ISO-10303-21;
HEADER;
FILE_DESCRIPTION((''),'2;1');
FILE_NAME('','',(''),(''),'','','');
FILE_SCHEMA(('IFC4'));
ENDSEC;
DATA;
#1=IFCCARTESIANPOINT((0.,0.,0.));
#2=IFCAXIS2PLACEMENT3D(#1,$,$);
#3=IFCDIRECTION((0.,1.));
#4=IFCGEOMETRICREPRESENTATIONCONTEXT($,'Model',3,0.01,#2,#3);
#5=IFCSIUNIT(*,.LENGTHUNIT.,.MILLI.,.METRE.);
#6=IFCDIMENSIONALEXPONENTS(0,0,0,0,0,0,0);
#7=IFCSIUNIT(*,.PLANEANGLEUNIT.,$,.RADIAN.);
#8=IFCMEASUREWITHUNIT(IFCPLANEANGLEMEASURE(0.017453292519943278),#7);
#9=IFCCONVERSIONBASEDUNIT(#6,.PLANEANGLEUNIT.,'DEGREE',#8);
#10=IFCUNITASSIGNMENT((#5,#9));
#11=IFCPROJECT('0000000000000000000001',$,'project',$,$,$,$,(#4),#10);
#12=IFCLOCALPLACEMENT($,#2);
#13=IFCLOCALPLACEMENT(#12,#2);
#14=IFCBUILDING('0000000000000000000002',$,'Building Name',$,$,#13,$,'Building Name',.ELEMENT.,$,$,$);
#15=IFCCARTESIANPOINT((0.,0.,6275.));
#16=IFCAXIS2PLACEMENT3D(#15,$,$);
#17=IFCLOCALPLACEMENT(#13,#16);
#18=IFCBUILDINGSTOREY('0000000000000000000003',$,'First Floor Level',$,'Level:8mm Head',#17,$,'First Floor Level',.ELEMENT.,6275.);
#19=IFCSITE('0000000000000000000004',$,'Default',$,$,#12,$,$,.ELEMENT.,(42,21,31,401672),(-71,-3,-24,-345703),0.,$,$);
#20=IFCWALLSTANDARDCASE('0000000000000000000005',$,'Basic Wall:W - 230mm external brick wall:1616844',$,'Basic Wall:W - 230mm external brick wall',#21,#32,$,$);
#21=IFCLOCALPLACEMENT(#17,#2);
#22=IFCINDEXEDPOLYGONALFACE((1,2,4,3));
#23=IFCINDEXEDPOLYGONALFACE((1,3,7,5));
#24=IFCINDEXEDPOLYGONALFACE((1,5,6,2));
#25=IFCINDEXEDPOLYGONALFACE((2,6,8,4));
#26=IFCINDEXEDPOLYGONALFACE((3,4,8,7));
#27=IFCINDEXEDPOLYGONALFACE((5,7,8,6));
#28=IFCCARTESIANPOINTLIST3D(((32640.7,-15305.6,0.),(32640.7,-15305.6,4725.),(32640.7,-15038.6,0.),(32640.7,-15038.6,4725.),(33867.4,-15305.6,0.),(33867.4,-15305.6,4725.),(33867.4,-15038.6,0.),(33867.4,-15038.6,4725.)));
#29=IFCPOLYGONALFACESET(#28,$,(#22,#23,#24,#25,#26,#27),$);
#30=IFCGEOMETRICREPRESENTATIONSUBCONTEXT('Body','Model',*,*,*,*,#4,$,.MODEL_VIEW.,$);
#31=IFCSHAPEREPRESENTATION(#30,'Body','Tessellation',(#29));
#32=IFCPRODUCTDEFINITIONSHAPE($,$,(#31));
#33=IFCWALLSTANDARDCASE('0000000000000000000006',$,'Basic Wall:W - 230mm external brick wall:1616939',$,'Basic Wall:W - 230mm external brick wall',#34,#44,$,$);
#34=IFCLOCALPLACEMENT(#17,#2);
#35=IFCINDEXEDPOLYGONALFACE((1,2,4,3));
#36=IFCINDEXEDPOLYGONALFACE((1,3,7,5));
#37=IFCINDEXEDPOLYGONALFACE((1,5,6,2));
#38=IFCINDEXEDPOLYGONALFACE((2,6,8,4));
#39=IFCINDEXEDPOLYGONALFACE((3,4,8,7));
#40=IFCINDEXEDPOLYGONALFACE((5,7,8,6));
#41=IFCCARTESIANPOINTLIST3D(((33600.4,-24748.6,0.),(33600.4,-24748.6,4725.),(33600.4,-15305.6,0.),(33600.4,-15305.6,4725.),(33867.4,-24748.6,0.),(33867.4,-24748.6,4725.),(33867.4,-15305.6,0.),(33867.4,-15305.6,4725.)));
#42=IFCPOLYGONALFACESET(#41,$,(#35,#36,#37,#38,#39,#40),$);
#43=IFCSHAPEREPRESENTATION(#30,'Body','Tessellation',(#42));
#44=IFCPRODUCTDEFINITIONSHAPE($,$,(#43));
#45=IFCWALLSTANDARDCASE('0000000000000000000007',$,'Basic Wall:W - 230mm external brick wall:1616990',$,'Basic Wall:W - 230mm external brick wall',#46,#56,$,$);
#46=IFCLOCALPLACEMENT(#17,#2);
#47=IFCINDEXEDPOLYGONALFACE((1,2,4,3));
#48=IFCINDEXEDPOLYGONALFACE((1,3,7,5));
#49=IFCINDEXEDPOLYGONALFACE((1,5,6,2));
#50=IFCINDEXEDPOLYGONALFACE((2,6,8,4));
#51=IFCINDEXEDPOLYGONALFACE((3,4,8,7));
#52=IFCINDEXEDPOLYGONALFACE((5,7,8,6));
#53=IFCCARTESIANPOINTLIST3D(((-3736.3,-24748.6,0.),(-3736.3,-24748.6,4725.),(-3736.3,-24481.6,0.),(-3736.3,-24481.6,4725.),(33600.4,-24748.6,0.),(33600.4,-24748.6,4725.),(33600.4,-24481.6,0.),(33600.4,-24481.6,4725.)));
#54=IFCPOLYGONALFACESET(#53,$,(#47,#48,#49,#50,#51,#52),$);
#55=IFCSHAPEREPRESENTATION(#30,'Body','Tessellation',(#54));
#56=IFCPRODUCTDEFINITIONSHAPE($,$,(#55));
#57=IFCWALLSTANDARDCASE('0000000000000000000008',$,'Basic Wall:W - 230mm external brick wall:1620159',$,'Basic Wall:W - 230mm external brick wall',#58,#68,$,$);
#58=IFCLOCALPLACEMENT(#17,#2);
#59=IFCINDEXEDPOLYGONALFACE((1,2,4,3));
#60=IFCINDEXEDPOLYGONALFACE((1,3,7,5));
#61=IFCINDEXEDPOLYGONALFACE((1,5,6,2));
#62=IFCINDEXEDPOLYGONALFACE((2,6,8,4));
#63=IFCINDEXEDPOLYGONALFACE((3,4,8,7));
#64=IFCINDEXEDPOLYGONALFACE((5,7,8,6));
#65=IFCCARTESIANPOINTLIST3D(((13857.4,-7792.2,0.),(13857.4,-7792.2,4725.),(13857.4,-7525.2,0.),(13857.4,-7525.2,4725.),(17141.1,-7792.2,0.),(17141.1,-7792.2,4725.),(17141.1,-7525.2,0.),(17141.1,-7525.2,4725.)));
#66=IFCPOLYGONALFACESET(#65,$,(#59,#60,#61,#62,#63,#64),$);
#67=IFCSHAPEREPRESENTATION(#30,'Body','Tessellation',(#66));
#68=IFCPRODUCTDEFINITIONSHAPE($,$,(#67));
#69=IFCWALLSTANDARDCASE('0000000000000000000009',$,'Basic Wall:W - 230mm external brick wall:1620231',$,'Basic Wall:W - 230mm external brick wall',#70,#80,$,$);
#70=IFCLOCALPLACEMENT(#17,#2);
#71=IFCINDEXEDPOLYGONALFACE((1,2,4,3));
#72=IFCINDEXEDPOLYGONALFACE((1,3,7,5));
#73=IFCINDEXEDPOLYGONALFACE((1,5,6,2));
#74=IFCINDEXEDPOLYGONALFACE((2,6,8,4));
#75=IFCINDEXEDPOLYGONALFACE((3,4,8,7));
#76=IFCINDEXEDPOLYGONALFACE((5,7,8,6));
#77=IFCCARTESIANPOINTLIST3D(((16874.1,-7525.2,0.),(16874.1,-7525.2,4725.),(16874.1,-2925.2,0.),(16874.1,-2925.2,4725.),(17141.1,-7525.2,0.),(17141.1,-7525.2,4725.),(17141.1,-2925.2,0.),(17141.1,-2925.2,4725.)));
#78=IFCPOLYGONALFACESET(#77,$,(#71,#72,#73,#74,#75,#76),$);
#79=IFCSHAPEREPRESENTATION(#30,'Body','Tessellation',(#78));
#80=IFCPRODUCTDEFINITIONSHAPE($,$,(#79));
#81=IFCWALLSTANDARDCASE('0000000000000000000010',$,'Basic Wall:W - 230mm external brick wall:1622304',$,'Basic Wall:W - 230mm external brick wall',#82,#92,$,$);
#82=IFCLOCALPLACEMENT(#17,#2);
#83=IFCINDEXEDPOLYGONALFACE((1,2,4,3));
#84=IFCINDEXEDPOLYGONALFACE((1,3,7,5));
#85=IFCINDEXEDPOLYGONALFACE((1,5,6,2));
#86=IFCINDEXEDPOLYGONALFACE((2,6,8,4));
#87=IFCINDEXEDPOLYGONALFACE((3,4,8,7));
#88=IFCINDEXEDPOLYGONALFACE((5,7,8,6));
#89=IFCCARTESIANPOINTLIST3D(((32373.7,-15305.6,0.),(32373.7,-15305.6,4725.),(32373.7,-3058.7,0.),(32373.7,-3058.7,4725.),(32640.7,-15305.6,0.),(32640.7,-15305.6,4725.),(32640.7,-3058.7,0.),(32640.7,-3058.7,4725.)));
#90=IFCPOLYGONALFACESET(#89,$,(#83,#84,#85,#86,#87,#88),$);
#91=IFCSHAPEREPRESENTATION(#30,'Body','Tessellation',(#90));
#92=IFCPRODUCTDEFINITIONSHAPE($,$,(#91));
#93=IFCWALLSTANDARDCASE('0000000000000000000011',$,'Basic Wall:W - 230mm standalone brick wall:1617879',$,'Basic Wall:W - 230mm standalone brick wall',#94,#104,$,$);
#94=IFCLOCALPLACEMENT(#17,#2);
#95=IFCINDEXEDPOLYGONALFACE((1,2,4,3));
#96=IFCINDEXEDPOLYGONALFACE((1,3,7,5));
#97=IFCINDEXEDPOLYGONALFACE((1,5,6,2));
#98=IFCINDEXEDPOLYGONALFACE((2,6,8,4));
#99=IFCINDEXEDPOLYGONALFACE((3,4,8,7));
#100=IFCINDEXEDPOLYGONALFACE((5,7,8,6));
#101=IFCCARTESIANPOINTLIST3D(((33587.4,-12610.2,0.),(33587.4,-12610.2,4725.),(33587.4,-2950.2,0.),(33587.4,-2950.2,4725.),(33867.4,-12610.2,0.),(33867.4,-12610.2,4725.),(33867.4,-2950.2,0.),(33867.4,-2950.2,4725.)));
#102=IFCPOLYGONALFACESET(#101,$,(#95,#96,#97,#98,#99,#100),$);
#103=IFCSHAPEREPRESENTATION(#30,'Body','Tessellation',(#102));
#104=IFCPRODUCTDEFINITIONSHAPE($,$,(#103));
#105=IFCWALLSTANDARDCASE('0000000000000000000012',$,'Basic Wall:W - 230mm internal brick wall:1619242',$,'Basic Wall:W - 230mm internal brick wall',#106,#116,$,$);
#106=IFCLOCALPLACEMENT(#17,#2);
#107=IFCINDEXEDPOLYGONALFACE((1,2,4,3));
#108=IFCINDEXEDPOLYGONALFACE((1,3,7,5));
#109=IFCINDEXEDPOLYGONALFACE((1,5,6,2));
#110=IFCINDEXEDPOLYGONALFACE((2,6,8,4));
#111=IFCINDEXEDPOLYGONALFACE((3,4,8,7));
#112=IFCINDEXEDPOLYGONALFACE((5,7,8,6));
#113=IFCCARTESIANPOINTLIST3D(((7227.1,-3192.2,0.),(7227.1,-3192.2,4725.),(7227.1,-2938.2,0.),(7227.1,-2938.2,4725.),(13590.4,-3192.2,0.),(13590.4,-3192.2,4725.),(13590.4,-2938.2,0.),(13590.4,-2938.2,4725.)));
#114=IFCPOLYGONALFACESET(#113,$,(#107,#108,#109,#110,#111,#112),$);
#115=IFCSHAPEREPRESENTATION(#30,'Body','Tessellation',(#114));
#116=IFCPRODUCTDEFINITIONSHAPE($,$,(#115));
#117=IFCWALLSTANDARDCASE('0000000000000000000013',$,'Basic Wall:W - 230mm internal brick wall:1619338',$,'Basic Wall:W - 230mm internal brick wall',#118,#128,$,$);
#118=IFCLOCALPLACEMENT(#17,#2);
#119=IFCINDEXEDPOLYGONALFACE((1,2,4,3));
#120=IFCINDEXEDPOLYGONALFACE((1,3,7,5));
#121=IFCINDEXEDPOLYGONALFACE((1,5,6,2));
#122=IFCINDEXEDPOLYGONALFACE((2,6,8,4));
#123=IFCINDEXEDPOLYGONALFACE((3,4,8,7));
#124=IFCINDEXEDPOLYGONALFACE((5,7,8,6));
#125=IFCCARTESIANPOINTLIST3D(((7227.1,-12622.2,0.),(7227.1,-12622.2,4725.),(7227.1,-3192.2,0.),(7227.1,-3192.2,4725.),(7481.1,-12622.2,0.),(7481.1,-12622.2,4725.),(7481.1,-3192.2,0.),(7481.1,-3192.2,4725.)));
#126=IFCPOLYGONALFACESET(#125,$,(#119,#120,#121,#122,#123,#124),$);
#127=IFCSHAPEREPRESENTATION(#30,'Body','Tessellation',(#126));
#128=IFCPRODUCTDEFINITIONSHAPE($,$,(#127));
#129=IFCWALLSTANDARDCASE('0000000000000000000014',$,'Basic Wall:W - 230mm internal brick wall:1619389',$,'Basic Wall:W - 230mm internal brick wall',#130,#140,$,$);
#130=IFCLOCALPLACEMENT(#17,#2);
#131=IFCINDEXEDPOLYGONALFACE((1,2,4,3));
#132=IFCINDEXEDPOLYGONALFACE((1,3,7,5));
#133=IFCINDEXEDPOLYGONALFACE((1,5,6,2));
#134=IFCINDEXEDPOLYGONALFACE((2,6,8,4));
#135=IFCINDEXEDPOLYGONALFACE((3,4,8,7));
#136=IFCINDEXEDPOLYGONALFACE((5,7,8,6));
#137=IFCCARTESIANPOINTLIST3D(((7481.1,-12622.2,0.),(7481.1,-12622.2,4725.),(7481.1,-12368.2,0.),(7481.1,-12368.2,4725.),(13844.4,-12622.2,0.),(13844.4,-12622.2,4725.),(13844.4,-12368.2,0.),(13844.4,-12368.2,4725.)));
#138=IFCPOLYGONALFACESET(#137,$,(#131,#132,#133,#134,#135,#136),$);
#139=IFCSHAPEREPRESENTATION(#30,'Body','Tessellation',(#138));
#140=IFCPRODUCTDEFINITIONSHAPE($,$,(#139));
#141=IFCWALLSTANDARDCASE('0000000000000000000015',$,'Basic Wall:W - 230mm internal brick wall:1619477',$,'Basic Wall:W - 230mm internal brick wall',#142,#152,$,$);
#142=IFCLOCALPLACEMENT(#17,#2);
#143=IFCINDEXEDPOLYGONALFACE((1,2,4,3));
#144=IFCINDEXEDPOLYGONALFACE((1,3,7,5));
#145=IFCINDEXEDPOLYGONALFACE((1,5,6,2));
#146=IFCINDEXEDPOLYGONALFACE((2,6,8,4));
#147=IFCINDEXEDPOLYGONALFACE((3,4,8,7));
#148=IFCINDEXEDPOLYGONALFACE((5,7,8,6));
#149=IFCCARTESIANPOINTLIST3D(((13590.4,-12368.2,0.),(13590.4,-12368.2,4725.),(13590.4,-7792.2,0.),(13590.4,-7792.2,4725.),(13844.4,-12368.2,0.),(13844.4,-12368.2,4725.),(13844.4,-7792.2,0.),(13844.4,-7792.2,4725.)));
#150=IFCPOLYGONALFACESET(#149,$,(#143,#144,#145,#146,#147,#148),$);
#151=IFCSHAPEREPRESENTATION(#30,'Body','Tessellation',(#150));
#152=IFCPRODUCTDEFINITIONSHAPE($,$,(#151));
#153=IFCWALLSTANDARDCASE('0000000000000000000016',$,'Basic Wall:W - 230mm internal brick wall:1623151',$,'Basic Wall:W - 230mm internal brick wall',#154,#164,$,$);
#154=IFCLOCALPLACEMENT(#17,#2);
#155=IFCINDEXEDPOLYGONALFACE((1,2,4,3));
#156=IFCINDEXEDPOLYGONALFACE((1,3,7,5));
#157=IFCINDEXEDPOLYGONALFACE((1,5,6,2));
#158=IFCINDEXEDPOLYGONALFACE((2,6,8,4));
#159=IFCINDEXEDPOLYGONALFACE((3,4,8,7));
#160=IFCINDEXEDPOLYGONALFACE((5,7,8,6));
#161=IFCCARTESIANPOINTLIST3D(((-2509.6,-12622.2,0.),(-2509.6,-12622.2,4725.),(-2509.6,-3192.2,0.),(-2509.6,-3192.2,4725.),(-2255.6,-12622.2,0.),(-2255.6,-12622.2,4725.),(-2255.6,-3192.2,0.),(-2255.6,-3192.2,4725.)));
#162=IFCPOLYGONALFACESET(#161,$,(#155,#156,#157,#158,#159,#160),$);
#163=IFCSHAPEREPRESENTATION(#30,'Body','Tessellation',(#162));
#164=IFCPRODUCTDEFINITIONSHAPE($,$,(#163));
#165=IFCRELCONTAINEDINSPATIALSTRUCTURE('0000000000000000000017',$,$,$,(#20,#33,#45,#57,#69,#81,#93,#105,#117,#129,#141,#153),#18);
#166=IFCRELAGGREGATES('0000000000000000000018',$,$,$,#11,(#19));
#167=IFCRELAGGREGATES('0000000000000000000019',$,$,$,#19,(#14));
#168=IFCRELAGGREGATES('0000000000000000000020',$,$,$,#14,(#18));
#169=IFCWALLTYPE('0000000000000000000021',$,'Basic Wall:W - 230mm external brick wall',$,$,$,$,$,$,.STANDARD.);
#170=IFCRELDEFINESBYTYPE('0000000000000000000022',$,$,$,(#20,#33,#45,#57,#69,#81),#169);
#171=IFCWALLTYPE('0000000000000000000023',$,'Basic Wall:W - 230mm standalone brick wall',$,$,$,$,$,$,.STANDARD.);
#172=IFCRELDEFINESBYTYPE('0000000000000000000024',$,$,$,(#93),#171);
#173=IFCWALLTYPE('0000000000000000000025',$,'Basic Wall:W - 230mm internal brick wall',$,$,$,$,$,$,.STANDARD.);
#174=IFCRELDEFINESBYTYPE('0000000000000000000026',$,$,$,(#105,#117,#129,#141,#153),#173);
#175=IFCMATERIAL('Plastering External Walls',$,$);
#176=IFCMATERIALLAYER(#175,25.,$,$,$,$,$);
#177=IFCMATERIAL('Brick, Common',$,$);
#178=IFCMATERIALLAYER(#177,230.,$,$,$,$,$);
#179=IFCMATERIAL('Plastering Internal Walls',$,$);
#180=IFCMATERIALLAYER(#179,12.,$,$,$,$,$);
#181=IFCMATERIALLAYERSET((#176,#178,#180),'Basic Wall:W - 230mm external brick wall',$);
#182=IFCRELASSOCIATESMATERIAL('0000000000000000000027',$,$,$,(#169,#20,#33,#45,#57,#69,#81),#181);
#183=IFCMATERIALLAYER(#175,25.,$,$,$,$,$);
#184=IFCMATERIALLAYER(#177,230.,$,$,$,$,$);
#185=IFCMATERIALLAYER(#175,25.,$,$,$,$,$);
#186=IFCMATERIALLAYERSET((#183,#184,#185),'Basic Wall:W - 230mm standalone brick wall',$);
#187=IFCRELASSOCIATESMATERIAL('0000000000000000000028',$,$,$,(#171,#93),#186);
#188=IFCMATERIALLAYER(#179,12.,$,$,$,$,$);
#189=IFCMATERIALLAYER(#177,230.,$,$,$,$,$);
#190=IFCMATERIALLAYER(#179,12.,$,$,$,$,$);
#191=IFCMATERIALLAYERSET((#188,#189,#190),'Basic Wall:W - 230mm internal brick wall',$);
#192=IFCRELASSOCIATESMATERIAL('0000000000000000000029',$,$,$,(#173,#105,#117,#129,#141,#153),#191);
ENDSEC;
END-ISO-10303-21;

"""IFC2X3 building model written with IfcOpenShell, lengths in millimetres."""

from ifc_helpers import new_model, entity, si_unit, converted_unit, direction, frame, frame_2d, origin, place, context, subcontext, project, spatial, rectangle, extrude, material, layer, layer_set, layer_usage, type_object, element, save


model = new_model("IFC2X3")

# Units and contexts
model_context = context("Model", 3, precision=0.01, world=origin(), true_north=direction((0.0, 1.0)))
body_context = subcontext(model_context, "Body", "Model", "MODEL_VIEW")
ifc_project = project(units=[si_unit("LENGTHUNIT", "METRE", prefix="MILLI"), converted_unit("PLANEANGLEUNIT", "DEGREE", entity("IfcPlaneAngleMeasure", 0.017453292519943278), si_unit("PLANEANGLEUNIT", "RADIAN"), dimensions=[0, 0, 0, 0, 0, 0, 0])], contexts=[model_context])

# Site, building, storey
site_placement = place(None, origin())
site = spatial("IfcSite", under=ifc_project, at=site_placement, Name="Default", CompositionType="ELEMENT", RefLatitude=(42, 21, 31, 401672), RefLongitude=(-71, -3, -24, -345703), RefElevation=0.0)
building_placement = place(site_placement, origin())
building = spatial("IfcBuilding", under=site, at=building_placement, Name="Building Name", LongName="Building Name", CompositionType="ELEMENT")
storey_placement = place(building_placement, frame((0.0, 0.0, 6275.0)))
storey = spatial("IfcBuildingStorey", under=building, at=storey_placement, Name="First Floor Level", ObjectType="Level:8mm Head", LongName="First Floor Level", CompositionType="ELEMENT", Elevation=6275.0)

# Walls
ifc_material_1 = material(Name="Plastering External Walls")
ifc_layer_1 = layer(ifc_material_1, 25.0)
ifc_material_2 = material(Name="Brick, Common")
ifc_layer_2 = layer(ifc_material_2, 230.0)
ifc_material_3 = material(Name="Plastering Internal Walls")
ifc_layer_3 = layer(ifc_material_3, 12.0)
ifc_layer_set_1 = layer_set([ifc_layer_1, ifc_layer_2, ifc_layer_3], Name="Basic Wall:W - 230mm external brick wall")
ifc_layer_usage_1 = layer_usage(ifc_layer_set_1, "AXIS2", "NEGATIVE", 133.5)
wall_type_1 = type_object("IfcWallType", Name="Basic Wall:W - 230mm external brick wall", PredefinedType="STANDARD", material=ifc_layer_set_1)
wall_1_placement = place(storey_placement, frame((32640.7, -15172.1, 0.0)))
element("IfcWallStandardCase", 1, at=wall_1_placement, inside=storey, type_object=wall_type_1, material=ifc_layer_usage_1, Name="Basic Wall:W - 230mm external brick wall:1616844", ObjectType="Basic Wall:W - 230mm external brick wall", context=body_context, shape_type="SweptSolid", body=[
    extrude(rectangle(XDim=1226.7, YDim=267.0, at=frame_2d((613.3, 0.0), x_axis=(-1.0, 0.0))), origin(), (0.0, 0.0, 1.0), 4725.0),
])
ifc_layer_usage_2 = layer_usage(ifc_layer_set_1, "AXIS2", "NEGATIVE", 133.5)
wall_2_placement = place(storey_placement, frame((33733.9, -15305.6, 0.0), z_axis=(0.0, 0.0, 1.0), x_axis=(0.0, -1.0, 0.0)))
element("IfcWallStandardCase", 2, at=wall_2_placement, inside=storey, type_object=wall_type_1, material=ifc_layer_usage_2, Name="Basic Wall:W - 230mm external brick wall:1616939", ObjectType="Basic Wall:W - 230mm external brick wall", context=body_context, shape_type="SweptSolid", body=[
    extrude(rectangle(XDim=9443.0, YDim=267.0, at=frame_2d((4721.5, 0.0), x_axis=(-1.0, 0.0))), origin(), (0.0, 0.0, 1.0), 4725.0),
])
ifc_layer_usage_3 = layer_usage(ifc_layer_set_1, "AXIS2", "NEGATIVE", 133.5)
wall_3_placement = place(storey_placement, frame((33600.4, -24615.1, 0.0), z_axis=(0.0, 0.0, 1.0), x_axis=(-1.0, 0.0, 0.0)))
element("IfcWallStandardCase", 3, at=wall_3_placement, inside=storey, type_object=wall_type_1, material=ifc_layer_usage_3, Name="Basic Wall:W - 230mm external brick wall:1616990", ObjectType="Basic Wall:W - 230mm external brick wall", context=body_context, shape_type="SweptSolid", body=[
    extrude(rectangle(XDim=37336.7, YDim=267.0, at=frame_2d((18668.3, 0.0), x_axis=(-1.0, 0.0))), origin(), (0.0, 0.0, 1.0), 4725.0),
])
ifc_layer_usage_4 = layer_usage(ifc_layer_set_1, "AXIS2", "NEGATIVE", 133.5)
wall_4_placement = place(storey_placement, frame((13857.4, -7658.7, 0.0)))
element("IfcWallStandardCase", 4, at=wall_4_placement, inside=storey, type_object=wall_type_1, material=ifc_layer_usage_4, Name="Basic Wall:W - 230mm external brick wall:1620159", ObjectType="Basic Wall:W - 230mm external brick wall", context=body_context, shape_type="SweptSolid", body=[
    extrude(rectangle(XDim=3283.7, YDim=267.0, at=frame_2d((1641.8, 0.0), x_axis=(-1.0, 0.0))), origin(), (0.0, 0.0, 1.0), 4725.0),
])
ifc_layer_usage_5 = layer_usage(ifc_layer_set_1, "AXIS2", "NEGATIVE", 133.5)
wall_5_placement = place(storey_placement, frame((17007.6, -7525.2, 0.0), z_axis=(0.0, 0.0, 1.0), x_axis=(0.0, 1.0, 0.0)))
element("IfcWallStandardCase", 5, at=wall_5_placement, inside=storey, type_object=wall_type_1, material=ifc_layer_usage_5, Name="Basic Wall:W - 230mm external brick wall:1620231", ObjectType="Basic Wall:W - 230mm external brick wall", context=body_context, shape_type="SweptSolid", body=[
    extrude(rectangle(XDim=4600.0, YDim=267.0, at=frame_2d((2300.0, 0.0), x_axis=(-1.0, 0.0))), origin(), (0.0, 0.0, 1.0), 4725.0),
])
ifc_layer_usage_6 = layer_usage(ifc_layer_set_1, "AXIS2", "NEGATIVE", 133.5)
wall_6_placement = place(storey_placement, frame((32507.2, -3058.7, 0.0), z_axis=(0.0, 0.0, 1.0), x_axis=(0.0, -1.0, 0.0)))
element("IfcWallStandardCase", 6, at=wall_6_placement, inside=storey, type_object=wall_type_1, material=ifc_layer_usage_6, Name="Basic Wall:W - 230mm external brick wall:1622304", ObjectType="Basic Wall:W - 230mm external brick wall", context=body_context, shape_type="SweptSolid", body=[
    extrude(rectangle(XDim=12246.8, YDim=267.0, at=frame_2d((6123.4, 0.0), x_axis=(-1.0, 0.0))), origin(), (0.0, 0.0, 1.0), 4725.0),
])
ifc_layer_4 = layer(ifc_material_1, 25.0)
ifc_layer_5 = layer(ifc_material_2, 230.0)
ifc_layer_6 = layer(ifc_material_1, 25.0)
ifc_layer_set_2 = layer_set([ifc_layer_4, ifc_layer_5, ifc_layer_6], Name="Basic Wall:W - 230mm standalone brick wall")
ifc_layer_usage_7 = layer_usage(ifc_layer_set_2, "AXIS2", "NEGATIVE", 140.0)
wall_type_2 = type_object("IfcWallType", Name="Basic Wall:W - 230mm standalone brick wall", PredefinedType="STANDARD", material=ifc_layer_set_2)
wall_7_placement = place(storey_placement, frame((33727.4, -12610.2, 0.0), z_axis=(0.0, 0.0, 1.0), x_axis=(0.0, 1.0, 0.0)))
element("IfcWallStandardCase", 7, at=wall_7_placement, inside=storey, type_object=wall_type_2, material=ifc_layer_usage_7, Name="Basic Wall:W - 230mm standalone brick wall:1617879", ObjectType="Basic Wall:W - 230mm standalone brick wall", context=body_context, shape_type="SweptSolid", body=[
    extrude(rectangle(XDim=9660.0, YDim=280.0, at=frame_2d((4830.0, 0.0), x_axis=(-1.0, 0.0))), origin(), (0.0, 0.0, 1.0), 4725.0),
])
ifc_layer_7 = layer(ifc_material_3, 12.0)
ifc_layer_8 = layer(ifc_material_2, 230.0)
ifc_layer_9 = layer(ifc_material_3, 12.0)
ifc_layer_set_3 = layer_set([ifc_layer_7, ifc_layer_8, ifc_layer_9], Name="Basic Wall:W - 230mm internal brick wall")
ifc_layer_usage_8 = layer_usage(ifc_layer_set_3, "AXIS2", "NEGATIVE", 127.0)
wall_type_3 = type_object("IfcWallType", Name="Basic Wall:W - 230mm internal brick wall", PredefinedType="STANDARD", material=ifc_layer_set_3)
wall_8_placement = place(storey_placement, frame((13590.4, -3065.2, 0.0), z_axis=(0.0, 0.0, 1.0), x_axis=(-1.0, 0.0, 0.0)))
element("IfcWallStandardCase", 8, at=wall_8_placement, inside=storey, type_object=wall_type_3, material=ifc_layer_usage_8, Name="Basic Wall:W - 230mm internal brick wall:1619242", ObjectType="Basic Wall:W - 230mm internal brick wall", context=body_context, shape_type="SweptSolid", body=[
    extrude(rectangle(XDim=6363.3, YDim=254.0, at=frame_2d((3181.7, 0.0), x_axis=(-1.0, 0.0))), origin(), (0.0, 0.0, 1.0), 4725.0),
])
ifc_layer_usage_9 = layer_usage(ifc_layer_set_3, "AXIS2", "NEGATIVE", 127.0)
wall_9_placement = place(storey_placement, frame((7354.1, -3192.2, 0.0), z_axis=(0.0, 0.0, 1.0), x_axis=(0.0, -1.0, 0.0)))
element("IfcWallStandardCase", 9, at=wall_9_placement, inside=storey, type_object=wall_type_3, material=ifc_layer_usage_9, Name="Basic Wall:W - 230mm internal brick wall:1619338", ObjectType="Basic Wall:W - 230mm internal brick wall", context=body_context, shape_type="SweptSolid", body=[
    extrude(rectangle(XDim=9430.0, YDim=254.0, at=frame_2d((4715.0, 0.0), x_axis=(-1.0, 0.0))), origin(), (0.0, 0.0, 1.0), 4725.0),
])
ifc_layer_usage_10 = layer_usage(ifc_layer_set_3, "AXIS2", "NEGATIVE", 127.0)
wall_10_placement = place(storey_placement, frame((7481.1, -12495.2, 0.0)))
element("IfcWallStandardCase", 10, at=wall_10_placement, inside=storey, type_object=wall_type_3, material=ifc_layer_usage_10, Name="Basic Wall:W - 230mm internal brick wall:1619389", ObjectType="Basic Wall:W - 230mm internal brick wall", context=body_context, shape_type="SweptSolid", body=[
    extrude(rectangle(XDim=6363.3, YDim=254.0, at=frame_2d((3181.7, 0.0), x_axis=(-1.0, 0.0))), origin(), (0.0, 0.0, 1.0), 4725.0),
])
ifc_layer_usage_11 = layer_usage(ifc_layer_set_3, "AXIS2", "NEGATIVE", 127.0)
wall_11_placement = place(storey_placement, frame((13717.4, -12368.2, 0.0), z_axis=(0.0, 0.0, 1.0), x_axis=(0.0, 1.0, 0.0)))
element("IfcWallStandardCase", 11, at=wall_11_placement, inside=storey, type_object=wall_type_3, material=ifc_layer_usage_11, Name="Basic Wall:W - 230mm internal brick wall:1619477", ObjectType="Basic Wall:W - 230mm internal brick wall", context=body_context, shape_type="SweptSolid", body=[
    extrude(rectangle(XDim=4576.0, YDim=254.0, at=frame_2d((2288.0, 0.0), x_axis=(-1.0, 0.0))), origin(), (0.0, 0.0, 1.0), 4725.0),
])
ifc_layer_usage_12 = layer_usage(ifc_layer_set_3, "AXIS2", "NEGATIVE", 127.0)
wall_12_placement = place(storey_placement, frame((-2382.6, -3192.2, 0.0), z_axis=(0.0, 0.0, 1.0), x_axis=(0.0, -1.0, 0.0)))
element("IfcWallStandardCase", 12, at=wall_12_placement, inside=storey, type_object=wall_type_3, material=ifc_layer_usage_12, Name="Basic Wall:W - 230mm internal brick wall:1623151", ObjectType="Basic Wall:W - 230mm internal brick wall", context=body_context, shape_type="SweptSolid", body=[
    extrude(rectangle(XDim=9430.0, YDim=254.0, at=frame_2d((4715.0, 0.0), x_axis=(-1.0, 0.0))), origin(), (0.0, 0.0, 1.0), 4725.0),
])

save(model, "model.ifc")
